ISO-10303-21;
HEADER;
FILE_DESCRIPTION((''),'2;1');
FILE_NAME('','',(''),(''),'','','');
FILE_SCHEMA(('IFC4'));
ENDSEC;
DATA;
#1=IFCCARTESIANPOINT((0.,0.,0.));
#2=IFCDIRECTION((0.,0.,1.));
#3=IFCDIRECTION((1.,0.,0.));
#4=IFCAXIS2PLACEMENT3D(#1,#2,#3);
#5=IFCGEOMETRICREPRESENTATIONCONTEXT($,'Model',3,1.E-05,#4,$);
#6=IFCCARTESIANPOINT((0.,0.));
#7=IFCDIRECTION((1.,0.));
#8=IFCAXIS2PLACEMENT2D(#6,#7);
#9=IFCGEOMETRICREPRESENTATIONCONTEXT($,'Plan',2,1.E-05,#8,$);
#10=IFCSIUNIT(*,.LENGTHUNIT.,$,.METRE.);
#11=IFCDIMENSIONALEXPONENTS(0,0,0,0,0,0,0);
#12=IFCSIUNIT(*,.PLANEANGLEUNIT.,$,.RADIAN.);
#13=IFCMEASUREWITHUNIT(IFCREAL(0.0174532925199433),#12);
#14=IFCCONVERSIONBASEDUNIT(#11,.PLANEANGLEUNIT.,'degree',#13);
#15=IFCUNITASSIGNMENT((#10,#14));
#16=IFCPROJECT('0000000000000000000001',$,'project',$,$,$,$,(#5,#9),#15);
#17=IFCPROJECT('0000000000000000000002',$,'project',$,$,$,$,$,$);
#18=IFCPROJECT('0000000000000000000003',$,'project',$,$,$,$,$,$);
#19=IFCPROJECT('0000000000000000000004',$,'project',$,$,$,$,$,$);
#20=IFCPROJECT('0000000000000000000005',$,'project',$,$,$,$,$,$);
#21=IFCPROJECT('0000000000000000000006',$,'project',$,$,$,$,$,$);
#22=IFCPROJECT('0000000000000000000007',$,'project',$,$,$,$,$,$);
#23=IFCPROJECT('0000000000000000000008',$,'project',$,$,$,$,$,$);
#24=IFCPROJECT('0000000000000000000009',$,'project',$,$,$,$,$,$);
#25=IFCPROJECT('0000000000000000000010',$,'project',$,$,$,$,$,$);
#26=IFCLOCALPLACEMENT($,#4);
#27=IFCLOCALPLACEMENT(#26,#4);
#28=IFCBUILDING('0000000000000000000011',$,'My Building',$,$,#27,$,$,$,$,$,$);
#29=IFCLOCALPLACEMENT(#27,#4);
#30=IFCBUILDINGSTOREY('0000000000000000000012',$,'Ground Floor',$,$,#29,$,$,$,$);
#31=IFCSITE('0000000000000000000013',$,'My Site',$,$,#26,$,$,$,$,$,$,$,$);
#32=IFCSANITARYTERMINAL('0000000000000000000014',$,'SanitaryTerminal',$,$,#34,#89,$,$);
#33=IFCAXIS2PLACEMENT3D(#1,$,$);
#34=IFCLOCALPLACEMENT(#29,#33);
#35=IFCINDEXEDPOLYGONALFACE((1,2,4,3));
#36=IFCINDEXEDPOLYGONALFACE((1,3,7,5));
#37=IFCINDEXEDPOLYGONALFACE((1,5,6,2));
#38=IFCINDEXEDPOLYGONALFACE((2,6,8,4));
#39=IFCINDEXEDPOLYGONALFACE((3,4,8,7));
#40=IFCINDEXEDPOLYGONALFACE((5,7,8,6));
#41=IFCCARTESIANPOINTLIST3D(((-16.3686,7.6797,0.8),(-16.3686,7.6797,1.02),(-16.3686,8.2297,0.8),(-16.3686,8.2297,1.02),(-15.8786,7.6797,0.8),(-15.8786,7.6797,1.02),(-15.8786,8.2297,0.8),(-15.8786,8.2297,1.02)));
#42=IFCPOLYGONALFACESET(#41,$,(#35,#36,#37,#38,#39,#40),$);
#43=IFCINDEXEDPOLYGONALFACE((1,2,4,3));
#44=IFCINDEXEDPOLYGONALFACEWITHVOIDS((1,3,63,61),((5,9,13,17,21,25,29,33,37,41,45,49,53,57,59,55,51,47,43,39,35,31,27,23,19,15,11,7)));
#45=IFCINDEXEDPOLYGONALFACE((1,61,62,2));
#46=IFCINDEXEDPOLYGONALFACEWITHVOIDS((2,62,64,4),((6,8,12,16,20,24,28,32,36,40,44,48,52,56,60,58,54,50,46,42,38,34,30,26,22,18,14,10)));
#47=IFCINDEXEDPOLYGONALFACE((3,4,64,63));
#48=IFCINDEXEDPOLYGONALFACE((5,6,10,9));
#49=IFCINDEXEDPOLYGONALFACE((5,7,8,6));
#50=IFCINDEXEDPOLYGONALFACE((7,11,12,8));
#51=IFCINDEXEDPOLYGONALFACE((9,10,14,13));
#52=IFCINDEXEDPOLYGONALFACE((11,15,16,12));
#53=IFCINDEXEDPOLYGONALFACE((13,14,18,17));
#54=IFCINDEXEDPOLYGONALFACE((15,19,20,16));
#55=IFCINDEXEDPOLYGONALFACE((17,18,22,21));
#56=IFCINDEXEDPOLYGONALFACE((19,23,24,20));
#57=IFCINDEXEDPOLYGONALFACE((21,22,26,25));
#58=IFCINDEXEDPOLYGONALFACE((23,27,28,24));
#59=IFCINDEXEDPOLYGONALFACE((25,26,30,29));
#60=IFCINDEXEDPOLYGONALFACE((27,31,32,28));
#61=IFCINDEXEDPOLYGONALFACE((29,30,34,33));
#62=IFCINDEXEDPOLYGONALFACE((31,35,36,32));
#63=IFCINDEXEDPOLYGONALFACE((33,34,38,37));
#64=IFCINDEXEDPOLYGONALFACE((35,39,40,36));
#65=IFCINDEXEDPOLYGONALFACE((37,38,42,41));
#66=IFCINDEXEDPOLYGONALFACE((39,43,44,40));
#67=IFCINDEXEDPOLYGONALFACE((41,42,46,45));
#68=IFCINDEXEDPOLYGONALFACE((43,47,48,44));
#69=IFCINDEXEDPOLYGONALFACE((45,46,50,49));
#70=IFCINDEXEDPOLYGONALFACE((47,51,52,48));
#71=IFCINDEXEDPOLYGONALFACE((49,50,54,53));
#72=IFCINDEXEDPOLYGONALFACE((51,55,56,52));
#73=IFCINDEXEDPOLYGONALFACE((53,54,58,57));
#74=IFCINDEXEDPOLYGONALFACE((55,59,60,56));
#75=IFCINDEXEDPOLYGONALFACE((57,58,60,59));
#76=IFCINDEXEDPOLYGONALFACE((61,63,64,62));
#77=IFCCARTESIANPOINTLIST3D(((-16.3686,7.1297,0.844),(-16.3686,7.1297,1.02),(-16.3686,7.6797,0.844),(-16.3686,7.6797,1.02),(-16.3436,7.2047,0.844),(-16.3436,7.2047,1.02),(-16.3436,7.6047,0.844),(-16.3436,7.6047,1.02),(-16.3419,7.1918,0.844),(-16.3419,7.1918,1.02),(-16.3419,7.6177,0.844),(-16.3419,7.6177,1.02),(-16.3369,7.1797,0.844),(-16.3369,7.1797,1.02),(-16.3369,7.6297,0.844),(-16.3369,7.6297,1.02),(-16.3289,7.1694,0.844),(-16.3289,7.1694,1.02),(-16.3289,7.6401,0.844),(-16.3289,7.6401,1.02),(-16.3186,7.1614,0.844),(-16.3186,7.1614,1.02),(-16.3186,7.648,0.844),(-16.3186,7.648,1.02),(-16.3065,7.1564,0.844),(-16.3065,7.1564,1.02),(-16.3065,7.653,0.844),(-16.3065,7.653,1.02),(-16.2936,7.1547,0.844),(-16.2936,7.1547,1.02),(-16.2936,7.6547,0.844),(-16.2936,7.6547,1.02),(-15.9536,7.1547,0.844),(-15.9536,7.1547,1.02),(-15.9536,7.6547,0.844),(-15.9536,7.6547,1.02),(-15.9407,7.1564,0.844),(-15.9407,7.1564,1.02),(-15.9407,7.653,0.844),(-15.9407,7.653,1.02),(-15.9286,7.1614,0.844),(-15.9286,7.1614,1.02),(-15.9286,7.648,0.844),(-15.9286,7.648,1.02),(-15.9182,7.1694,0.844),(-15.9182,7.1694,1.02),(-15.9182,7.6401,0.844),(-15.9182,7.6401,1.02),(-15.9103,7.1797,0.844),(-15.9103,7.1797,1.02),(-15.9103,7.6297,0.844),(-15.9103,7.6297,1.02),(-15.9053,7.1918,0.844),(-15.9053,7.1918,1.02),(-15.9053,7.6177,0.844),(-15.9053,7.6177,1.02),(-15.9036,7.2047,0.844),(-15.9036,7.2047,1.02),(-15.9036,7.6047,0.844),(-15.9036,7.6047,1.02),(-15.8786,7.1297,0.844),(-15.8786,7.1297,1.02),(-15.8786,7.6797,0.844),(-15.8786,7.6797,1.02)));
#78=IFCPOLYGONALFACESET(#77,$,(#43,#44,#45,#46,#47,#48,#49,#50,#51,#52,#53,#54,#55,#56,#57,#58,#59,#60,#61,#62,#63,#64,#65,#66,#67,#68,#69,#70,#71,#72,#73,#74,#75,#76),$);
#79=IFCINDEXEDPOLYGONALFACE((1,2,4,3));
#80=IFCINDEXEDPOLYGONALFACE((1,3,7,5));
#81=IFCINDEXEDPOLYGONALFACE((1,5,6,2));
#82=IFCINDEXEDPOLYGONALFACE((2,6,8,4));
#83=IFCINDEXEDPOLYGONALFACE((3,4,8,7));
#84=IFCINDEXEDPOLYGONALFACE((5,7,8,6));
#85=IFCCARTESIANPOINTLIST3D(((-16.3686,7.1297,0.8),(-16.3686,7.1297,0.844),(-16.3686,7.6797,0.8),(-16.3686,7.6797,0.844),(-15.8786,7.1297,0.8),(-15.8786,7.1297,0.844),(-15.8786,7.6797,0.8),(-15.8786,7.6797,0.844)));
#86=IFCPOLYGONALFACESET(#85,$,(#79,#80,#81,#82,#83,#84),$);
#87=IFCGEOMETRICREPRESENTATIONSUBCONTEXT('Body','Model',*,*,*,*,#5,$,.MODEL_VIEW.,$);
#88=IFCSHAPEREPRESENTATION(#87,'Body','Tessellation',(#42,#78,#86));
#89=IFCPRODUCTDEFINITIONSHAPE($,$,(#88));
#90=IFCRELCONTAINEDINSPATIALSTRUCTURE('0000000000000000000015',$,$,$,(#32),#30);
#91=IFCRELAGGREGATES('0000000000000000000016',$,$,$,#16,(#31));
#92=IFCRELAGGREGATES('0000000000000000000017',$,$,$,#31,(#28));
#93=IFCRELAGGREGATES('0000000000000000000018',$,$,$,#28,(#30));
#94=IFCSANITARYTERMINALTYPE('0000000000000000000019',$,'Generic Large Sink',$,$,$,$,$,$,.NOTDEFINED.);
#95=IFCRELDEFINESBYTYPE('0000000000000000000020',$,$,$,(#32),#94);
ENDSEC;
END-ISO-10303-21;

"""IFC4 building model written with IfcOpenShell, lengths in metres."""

from ifc_helpers import new_model, entity, si_unit, converted_unit, frame, origin_with_axes, origin_2d_with_axis, place, context, subcontext, project, spatial, line, indexed_curve, outline, extrude, shape, source, transform, mapped, type_object, type_shapes, element, save


model = new_model("IFC4")

# Units and contexts
model_context = context("Model", 3, precision=1e-05, world=origin_with_axes())
plan_context = context("Plan", 2, precision=1e-05, world=origin_2d_with_axis())
body_context_1 = subcontext(model_context, "Body", "Model", "MODEL_VIEW")
body_context_2 = subcontext(plan_context, "Body", "Plan", "PLAN_VIEW")
ifc_project_1 = project(units=[si_unit("LENGTHUNIT", "METRE"), converted_unit("PLANEANGLEUNIT", "degree", entity("IfcReal", 0.0174532925199433), si_unit("PLANEANGLEUNIT", "RADIAN"), dimensions=[0, 0, 0, 0, 0, 0, 0])], contexts=[model_context, plan_context])
ifc_project_2 = project()
ifc_project_3 = project()
ifc_project_4 = project()
ifc_project_5 = project()
ifc_project_6 = project()
ifc_project_7 = project()
ifc_project_8 = project()
ifc_project_9 = project()
ifc_project_10 = project()

# Site, building, storey
site_placement = place(None, origin_with_axes())
site = spatial("IfcSite", under=ifc_project_1, at=site_placement, Name="My Site")
building_placement = place(site_placement, origin_with_axes())
building = spatial("IfcBuilding", under=site, at=building_placement, Name="My Building")
storey_placement = place(building_placement, origin_with_axes())
storey = spatial("IfcBuildingStorey", under=building, at=storey_placement, Name="Ground Floor")

# Sanitary terminal
sanitary_terminal_type_1 = type_object("IfcSanitaryTerminalType", Name="Generic Large Sink", PredefinedType="NOTDEFINED")
shared_indexed_poly_curve = entity("IfcIndexedPolyCurve", entity("IfcCartesianPointList2D", [[0.55, 0.0], [1.1, 0.0], [1.1, 0.49], [0.55, 0.49]]), [entity("IfcLineIndex", [1, 2]), entity("IfcLineIndex", [2, 3]), entity("IfcLineIndex", [3, 4]), entity("IfcLineIndex", [4, 1])])
shared_shape_1 = source(origin_with_axes(), body_context_1, "Body", "SweptSolid", [
    extrude(outline(indexed_curve([(0.0, 0.0), (0.55, 0.0), (0.55, 0.49), (0.0, 0.49)], segments=[line(1, 2), line(2, 3), line(3, 4), line(4, 1)])), frame((-0.55, -0.49, 0.0), z_axis=(0.0, 0.0, 1.0), x_axis=(1.0, 0.0, 0.0)), (0.0, 0.0, 1.0), 0.22),
    entity("IfcExtrudedAreaSolid", entity("IfcArbitraryProfileDefWithVoids", "AREA", None, shared_indexed_poly_curve, [entity("IfcIndexedPolyCurve", entity("IfcCartesianPointList2D", [[0.575, 0.075], [0.5896, 0.0396], [0.625, 0.025], [1.025, 0.025], [1.0604, 0.0396], [1.075, 0.075], [1.075, 0.415], [1.0604, 0.4504], [1.025, 0.465], [0.625, 0.465], [0.5896, 0.4504], [0.575, 0.415]]), [entity("IfcLineIndex", [12, 1]), entity("IfcArcIndex", [1, 2, 3]), entity("IfcLineIndex", [3, 4]), entity("IfcArcIndex", [4, 5, 6]), entity("IfcLineIndex", [6, 7]), entity("IfcArcIndex", [7, 8, 9]), entity("IfcLineIndex", [9, 10]), entity("IfcArcIndex", [10, 11, 12]), entity("IfcLineIndex", [12, 1])])]), entity("IfcAxis2Placement3D", entity("IfcCartesianPoint", [-0.55, -0.49, 0.044]), entity("IfcDirection", [0.0, 0.0, 1.0]), entity("IfcDirection", [1.0, 0.0, 0.0])), entity("IfcDirection", [0.0, 0.0, 1.0]), 0.176),
    entity("IfcExtrudedAreaSolid", entity("IfcArbitraryClosedProfileDef", "AREA", None, shared_indexed_poly_curve), entity("IfcAxis2Placement3D", entity("IfcCartesianPoint", [-0.55, -0.49, 0.0]), entity("IfcDirection", [0.0, 0.0, 1.0]), entity("IfcDirection", [1.0, 0.0, 0.0])), entity("IfcDirection", [0.0, 0.0, 1.0]), 0.044),
])
shared_shape_2 = source(origin_with_axes(), body_context_2, "Body", "Curve2D", [
    entity("IfcIndexedPolyCurve", entity("IfcCartesianPointList2D", [[-0.55, -0.49], [0.55, -0.49], [0.55, 0.0], [-0.55, 0.0]]), [entity("IfcLineIndex", [1, 2]), entity("IfcLineIndex", [2, 3]), entity("IfcLineIndex", [3, 4]), entity("IfcLineIndex", [4, 1])]),
    entity("IfcIndexedPolyCurve", entity("IfcCartesianPointList2D", [[0.025, -0.415], [0.0396, -0.4504], [0.075, -0.465], [0.475, -0.465], [0.5104, -0.4504], [0.525, -0.415], [0.525, -0.075], [0.5104, -0.0396], [0.475, -0.025], [0.075, -0.025], [0.0396, -0.0396], [0.025, -0.075]]), [entity("IfcLineIndex", [12, 1]), entity("IfcArcIndex", [1, 2, 3]), entity("IfcLineIndex", [3, 4]), entity("IfcArcIndex", [4, 5, 6]), entity("IfcLineIndex", [6, 7]), entity("IfcArcIndex", [7, 8, 9]), entity("IfcLineIndex", [9, 10]), entity("IfcArcIndex", [10, 11, 12]), entity("IfcLineIndex", [12, 1])]),
    entity("IfcCircle", entity("IfcAxis2Placement2D", entity("IfcCartesianPoint", [0.275, -0.125])), 0.025),
    entity("IfcIndexedPolyCurve", entity("IfcCartesianPointList2D", [[0.275, -0.0125], [0.275, -0.1325]]), [entity("IfcLineIndex", [1, 2])]),
])
type_shapes(sanitary_terminal_type_1, [shared_shape_1, shared_shape_2])
sanitary_terminal_1_placement = place(storey_placement, frame((-15.8786, 7.6797, 0.8), z_axis=(0.0, 0.0, 1.0), x_axis=(0.0, -1.0, 0.0)))
element("IfcSanitaryTerminal", 1, at=sanitary_terminal_1_placement, inside=storey, type_object=sanitary_terminal_type_1, Name="SanitaryTerminal", shapes=[
    shape(body_context_1, "Body", "MappedRepresentation", [mapped(shared_shape_1, transform((0.0, 0.0, 0.0), x_axis=(1.0, 0.0, 0.0), y_axis=(0.0, 1.0, 0.0), z_axis=(0.0, 0.0, 1.0), scale=1.0))]),
    shape(body_context_2, "Body", "MappedRepresentation", [mapped(shared_shape_2, transform((0.0, 0.0, 0.0), x_axis=(1.0, 0.0, 0.0), y_axis=(0.0, 1.0, 0.0), z_axis=(0.0, 0.0, 1.0), scale=1.0))]),
])

save(model, "model.ifc")
